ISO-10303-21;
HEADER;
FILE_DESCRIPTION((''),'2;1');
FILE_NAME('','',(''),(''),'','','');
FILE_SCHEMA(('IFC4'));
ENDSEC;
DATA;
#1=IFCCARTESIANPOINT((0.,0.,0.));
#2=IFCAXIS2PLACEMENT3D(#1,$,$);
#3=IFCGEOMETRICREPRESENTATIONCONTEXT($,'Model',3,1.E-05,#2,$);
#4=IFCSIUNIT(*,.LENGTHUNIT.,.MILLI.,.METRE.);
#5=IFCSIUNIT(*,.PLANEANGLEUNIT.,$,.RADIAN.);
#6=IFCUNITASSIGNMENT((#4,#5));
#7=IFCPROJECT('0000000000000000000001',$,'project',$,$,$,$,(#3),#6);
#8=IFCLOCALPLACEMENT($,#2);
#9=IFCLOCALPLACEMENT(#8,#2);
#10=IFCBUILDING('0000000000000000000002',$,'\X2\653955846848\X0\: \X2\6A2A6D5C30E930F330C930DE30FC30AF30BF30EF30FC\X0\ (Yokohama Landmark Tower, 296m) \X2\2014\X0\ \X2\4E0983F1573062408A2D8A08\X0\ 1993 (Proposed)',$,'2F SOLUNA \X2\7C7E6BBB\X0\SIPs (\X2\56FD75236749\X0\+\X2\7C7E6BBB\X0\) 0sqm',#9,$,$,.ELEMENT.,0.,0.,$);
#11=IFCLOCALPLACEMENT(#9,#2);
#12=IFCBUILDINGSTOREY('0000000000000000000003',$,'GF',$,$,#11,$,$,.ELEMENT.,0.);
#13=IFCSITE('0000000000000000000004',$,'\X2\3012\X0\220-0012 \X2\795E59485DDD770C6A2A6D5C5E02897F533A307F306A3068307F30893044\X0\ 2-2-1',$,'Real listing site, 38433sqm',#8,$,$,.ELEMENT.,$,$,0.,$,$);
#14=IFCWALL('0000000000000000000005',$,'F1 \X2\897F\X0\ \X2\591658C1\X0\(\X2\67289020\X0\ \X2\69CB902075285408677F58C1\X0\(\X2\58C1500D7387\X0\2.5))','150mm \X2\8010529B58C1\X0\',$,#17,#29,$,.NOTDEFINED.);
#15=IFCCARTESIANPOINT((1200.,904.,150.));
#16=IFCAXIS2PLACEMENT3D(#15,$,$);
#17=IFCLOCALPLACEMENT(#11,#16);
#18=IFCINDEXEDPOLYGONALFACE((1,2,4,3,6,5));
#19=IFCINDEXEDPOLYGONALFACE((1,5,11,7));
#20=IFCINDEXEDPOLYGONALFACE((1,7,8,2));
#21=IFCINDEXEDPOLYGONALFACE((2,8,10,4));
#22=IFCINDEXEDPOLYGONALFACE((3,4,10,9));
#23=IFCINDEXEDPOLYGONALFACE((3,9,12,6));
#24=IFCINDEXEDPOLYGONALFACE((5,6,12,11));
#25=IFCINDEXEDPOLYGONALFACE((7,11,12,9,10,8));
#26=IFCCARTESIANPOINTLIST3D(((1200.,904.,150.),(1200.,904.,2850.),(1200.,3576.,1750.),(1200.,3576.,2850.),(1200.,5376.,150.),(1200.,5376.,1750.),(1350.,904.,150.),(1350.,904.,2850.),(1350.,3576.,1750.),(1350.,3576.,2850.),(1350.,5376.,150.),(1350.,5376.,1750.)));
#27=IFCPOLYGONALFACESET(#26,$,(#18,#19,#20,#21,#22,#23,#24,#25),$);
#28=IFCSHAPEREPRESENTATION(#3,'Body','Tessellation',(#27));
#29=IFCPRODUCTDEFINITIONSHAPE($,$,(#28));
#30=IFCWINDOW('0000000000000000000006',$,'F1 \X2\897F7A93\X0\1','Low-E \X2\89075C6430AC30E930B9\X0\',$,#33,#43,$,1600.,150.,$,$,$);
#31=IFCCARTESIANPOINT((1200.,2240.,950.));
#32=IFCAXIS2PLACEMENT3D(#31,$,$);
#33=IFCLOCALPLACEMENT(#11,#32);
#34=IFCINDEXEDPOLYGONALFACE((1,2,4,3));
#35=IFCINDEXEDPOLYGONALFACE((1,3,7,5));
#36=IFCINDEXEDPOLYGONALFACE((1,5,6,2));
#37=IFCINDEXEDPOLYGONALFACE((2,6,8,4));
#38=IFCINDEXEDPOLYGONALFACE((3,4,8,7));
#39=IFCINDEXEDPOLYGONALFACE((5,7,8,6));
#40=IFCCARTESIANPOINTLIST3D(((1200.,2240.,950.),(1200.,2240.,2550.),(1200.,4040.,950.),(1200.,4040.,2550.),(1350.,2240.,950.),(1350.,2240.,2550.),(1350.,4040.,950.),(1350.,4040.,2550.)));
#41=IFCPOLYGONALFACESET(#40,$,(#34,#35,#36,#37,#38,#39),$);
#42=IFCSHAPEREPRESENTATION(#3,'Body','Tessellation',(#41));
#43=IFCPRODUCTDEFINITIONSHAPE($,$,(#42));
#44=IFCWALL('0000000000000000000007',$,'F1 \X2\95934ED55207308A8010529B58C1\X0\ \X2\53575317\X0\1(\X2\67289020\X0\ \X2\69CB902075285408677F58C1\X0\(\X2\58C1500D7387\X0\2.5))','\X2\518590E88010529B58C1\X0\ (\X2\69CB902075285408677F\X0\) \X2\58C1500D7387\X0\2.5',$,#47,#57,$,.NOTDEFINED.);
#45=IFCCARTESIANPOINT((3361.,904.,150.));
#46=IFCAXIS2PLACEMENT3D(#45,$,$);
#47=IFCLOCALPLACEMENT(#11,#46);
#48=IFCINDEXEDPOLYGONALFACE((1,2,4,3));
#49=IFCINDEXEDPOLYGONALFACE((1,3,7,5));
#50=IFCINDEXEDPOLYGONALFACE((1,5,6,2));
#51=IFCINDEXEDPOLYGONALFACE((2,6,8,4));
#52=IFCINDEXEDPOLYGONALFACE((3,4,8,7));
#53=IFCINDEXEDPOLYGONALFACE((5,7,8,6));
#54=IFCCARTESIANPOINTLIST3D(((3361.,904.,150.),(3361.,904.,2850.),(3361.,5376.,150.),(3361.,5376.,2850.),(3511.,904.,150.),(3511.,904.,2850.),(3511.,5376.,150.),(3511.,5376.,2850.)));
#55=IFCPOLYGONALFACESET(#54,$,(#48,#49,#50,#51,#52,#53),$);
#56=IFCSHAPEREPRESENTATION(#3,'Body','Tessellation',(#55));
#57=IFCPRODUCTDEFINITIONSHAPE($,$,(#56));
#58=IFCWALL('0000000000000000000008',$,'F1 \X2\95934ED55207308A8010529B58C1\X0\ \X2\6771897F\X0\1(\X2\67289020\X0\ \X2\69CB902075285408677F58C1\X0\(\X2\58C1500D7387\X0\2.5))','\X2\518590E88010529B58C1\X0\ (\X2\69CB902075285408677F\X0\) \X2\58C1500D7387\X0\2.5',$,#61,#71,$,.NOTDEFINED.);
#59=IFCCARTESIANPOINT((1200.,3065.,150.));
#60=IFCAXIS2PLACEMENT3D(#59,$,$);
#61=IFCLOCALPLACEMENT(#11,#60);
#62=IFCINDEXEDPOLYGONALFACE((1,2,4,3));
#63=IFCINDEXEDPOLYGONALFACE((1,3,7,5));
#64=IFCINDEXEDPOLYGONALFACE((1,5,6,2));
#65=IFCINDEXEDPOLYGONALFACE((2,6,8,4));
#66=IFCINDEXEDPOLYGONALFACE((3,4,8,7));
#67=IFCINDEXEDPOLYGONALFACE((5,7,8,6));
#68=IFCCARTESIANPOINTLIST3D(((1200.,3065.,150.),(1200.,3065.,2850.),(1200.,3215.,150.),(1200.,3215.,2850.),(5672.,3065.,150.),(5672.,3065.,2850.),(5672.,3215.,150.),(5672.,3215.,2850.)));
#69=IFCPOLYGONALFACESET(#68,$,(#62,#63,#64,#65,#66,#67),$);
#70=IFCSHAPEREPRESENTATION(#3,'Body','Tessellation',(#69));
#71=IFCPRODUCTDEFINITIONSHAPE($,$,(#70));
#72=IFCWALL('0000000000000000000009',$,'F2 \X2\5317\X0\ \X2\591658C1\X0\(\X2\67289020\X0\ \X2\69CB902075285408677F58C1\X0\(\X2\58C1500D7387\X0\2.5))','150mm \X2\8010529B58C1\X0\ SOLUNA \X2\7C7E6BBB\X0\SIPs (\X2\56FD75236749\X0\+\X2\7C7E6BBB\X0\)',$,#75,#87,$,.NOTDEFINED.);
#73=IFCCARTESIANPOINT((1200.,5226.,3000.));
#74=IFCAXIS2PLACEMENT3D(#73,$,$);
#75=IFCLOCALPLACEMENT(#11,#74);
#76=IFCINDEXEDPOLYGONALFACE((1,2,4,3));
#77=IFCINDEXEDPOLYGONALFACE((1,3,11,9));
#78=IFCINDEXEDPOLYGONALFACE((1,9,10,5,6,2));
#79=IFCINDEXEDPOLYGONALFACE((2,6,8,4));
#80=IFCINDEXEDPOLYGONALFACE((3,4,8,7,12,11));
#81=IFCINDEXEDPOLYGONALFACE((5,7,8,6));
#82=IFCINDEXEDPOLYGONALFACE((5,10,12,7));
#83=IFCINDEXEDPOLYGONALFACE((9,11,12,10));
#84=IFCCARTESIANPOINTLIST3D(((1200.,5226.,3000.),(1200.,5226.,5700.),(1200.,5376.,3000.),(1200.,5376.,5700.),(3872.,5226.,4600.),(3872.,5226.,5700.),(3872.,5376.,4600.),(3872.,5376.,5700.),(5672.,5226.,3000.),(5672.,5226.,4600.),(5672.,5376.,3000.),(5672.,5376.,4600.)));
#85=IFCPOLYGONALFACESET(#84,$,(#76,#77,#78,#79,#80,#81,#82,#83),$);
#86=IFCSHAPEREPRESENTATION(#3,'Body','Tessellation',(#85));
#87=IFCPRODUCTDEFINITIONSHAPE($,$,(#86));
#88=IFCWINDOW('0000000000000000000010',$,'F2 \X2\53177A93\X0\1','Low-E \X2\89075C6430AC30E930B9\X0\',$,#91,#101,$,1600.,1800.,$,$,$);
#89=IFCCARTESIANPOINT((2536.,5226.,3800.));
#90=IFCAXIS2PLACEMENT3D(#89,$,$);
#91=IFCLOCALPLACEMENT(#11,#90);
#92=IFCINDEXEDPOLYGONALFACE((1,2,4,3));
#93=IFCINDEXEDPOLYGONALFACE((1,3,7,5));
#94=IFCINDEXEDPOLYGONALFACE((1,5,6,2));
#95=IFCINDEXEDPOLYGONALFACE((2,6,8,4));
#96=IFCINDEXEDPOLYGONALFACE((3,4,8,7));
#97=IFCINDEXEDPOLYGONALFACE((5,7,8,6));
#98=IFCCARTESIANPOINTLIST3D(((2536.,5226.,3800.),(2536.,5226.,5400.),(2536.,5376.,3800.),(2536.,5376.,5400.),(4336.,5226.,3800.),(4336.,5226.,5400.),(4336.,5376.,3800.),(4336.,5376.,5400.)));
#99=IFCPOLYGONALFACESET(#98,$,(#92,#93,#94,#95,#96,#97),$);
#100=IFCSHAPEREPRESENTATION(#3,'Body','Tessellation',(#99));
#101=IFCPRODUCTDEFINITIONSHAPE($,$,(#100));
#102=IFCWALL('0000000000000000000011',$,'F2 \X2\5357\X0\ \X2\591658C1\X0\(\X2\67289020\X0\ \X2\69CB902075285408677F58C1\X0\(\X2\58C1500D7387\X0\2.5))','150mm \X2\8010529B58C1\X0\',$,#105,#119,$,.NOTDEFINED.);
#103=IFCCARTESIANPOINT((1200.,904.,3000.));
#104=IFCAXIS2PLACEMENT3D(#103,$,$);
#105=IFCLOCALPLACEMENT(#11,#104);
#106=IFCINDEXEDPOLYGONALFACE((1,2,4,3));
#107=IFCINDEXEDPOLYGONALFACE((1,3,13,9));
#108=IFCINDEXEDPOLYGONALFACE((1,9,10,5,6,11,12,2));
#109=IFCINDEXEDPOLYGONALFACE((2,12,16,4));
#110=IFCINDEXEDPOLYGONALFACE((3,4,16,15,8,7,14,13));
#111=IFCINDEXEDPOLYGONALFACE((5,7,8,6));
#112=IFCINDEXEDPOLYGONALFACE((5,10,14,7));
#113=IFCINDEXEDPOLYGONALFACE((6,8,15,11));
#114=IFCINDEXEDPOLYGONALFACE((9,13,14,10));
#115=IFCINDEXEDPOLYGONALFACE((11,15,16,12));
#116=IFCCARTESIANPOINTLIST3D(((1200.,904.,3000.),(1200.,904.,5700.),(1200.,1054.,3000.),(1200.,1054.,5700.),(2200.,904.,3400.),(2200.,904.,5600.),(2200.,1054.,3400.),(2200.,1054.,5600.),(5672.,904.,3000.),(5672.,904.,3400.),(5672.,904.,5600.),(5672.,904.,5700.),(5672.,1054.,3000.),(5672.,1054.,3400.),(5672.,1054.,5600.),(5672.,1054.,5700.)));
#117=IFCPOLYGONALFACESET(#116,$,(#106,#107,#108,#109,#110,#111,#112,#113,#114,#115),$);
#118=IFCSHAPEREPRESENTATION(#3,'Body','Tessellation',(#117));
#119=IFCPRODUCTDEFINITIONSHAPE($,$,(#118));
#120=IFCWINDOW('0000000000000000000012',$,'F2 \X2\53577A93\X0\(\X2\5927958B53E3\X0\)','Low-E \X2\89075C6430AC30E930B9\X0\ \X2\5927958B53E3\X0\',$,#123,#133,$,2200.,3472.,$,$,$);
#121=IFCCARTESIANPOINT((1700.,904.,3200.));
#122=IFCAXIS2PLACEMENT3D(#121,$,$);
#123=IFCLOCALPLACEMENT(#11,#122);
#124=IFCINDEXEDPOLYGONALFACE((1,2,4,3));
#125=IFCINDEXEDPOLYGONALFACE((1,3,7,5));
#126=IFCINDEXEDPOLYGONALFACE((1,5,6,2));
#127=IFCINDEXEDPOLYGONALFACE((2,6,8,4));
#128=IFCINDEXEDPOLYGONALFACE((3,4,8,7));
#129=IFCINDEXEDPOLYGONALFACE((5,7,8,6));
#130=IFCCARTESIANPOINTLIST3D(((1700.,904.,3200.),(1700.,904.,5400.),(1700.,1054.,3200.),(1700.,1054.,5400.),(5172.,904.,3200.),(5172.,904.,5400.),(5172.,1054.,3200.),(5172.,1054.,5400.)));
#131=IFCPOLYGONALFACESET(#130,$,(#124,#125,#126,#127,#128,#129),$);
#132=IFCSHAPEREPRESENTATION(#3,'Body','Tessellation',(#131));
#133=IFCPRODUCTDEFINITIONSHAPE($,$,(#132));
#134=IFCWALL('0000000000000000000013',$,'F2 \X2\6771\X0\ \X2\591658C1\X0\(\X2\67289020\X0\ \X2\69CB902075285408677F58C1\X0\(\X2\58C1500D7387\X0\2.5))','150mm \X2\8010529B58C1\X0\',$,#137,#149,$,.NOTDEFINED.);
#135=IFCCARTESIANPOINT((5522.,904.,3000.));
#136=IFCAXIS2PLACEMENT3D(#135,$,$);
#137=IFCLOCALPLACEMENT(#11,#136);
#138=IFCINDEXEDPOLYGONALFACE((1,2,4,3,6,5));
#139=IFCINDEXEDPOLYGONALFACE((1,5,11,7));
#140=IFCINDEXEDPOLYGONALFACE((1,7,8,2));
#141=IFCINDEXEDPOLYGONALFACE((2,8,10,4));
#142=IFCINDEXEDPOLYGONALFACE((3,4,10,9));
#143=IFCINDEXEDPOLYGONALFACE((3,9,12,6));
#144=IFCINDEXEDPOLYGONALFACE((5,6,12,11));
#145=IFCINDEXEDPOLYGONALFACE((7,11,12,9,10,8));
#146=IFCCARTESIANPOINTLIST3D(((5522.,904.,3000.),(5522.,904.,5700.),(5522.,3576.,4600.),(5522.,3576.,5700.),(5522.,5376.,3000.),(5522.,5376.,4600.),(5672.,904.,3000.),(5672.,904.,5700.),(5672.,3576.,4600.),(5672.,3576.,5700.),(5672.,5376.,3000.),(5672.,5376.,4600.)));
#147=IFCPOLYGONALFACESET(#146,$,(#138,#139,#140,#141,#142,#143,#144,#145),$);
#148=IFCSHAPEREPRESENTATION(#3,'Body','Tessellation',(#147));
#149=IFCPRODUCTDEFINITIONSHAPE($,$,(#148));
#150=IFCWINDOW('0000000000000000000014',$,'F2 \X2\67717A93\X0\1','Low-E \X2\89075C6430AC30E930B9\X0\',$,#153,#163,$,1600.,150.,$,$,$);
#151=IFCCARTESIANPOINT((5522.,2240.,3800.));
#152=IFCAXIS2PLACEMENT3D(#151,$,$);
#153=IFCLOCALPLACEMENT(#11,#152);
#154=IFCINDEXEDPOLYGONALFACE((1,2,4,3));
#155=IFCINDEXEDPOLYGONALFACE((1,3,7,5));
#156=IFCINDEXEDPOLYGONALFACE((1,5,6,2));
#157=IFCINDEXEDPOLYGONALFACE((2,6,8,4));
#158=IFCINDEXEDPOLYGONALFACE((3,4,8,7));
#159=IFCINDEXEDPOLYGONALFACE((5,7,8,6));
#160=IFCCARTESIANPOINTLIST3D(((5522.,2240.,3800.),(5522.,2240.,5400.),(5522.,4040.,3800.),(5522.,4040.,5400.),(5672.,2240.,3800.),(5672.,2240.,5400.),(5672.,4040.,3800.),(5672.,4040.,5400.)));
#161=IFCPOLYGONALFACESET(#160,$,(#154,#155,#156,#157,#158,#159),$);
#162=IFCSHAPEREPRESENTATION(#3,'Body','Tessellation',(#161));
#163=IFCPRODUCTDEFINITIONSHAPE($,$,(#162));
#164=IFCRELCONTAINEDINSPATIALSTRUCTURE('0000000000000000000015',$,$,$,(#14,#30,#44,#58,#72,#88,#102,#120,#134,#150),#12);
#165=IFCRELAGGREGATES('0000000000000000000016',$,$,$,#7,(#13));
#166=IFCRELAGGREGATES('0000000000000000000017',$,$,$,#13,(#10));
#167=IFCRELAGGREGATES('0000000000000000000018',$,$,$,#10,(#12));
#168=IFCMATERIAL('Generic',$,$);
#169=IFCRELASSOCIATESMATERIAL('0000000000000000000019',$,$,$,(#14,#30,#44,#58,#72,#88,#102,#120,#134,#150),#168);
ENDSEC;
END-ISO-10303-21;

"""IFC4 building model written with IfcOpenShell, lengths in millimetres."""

from ifc_helpers import new_model, si_unit, frame, frame_2d, origin, place, context, project, spatial, rectangle, extrude, material, element, fill, save


model = new_model("IFC4")

# Units and contexts
model_context = context("Model", 3, precision=1e-05, world=origin())
ifc_project = project(units=[si_unit("LENGTHUNIT", "METRE", prefix="MILLI"), si_unit("PLANEANGLEUNIT", "RADIAN")], contexts=[model_context])

# Site, building, storey
site_placement = place(None, origin())
site = spatial("IfcSite", under=ifc_project, at=site_placement, Name="〒220-0012 神奈川県横浜市西区みなとみらい 2-2-1", ObjectType="Real listing site, 38433sqm", CompositionType="ELEMENT", RefElevation=0.0)
building_placement = place(site_placement, origin())
building = spatial("IfcBuilding", under=site, at=building_placement, Name="改善案: 横浜ランドマークタワー (Yokohama Landmark Tower, 296m) — 三菱地所設計 1993 (Proposed)", ObjectType="2F SOLUNA 籾殻SIPs (国産杉+籾殻) 0sqm", CompositionType="ELEMENT", ElevationOfRefHeight=0.0, ElevationOfTerrain=0.0)
storey_placement = place(building_placement, origin())
storey = spatial("IfcBuildingStorey", under=building, at=storey_placement, Name="GF", CompositionType="ELEMENT", Elevation=0.0)

# Shared definitions
ifc_material_1 = material(Name="Generic")

# Wall, opening, window
wall_1_placement = place(storey_placement, frame((1200.0, 904.0, 150.0)))
wall_1 = element("IfcWall", 1, at=wall_1_placement, inside=storey, material=ifc_material_1, Name="F1 西 外壁(木造 構造用合板壁(壁倍率2.5))", Description="150mm 耐力壁", PredefinedType="NOTDEFINED", context=model_context, shape_type="SweptSolid", body=[
    extrude(rectangle(XDim=150.0, YDim=4472.0, at=frame_2d((75.0, 2236.0))), frame((1200.0, 904.0, 150.0)), (0.0, 0.0, 1.0), 2700.0),
])
opening_1_placement = place(storey_placement, frame((1200.0, 2240.0, 950.0)))
opening_1 = element("IfcOpeningElement", 2, at=opening_1_placement, cuts=wall_1, PredefinedType="NOTDEFINED", context=model_context, shape_type="SweptSolid", body=[
    extrude(rectangle(XDim=150.0, YDim=1800.0, at=frame_2d((75.0, 900.0))), frame((1200.0, 2240.0, 950.0)), (0.0, 0.0, 1.0), 1600.0),
])
window_1_placement = place(storey_placement, frame((1200.0, 2240.0, 950.0)))
window_1 = element("IfcWindow", 3, at=window_1_placement, inside=storey, material=ifc_material_1, Name="F1 西窓1", Description="Low-E 複層ガラス", OverallHeight=1600.0, OverallWidth=150.0, context=model_context, shape_type="SweptSolid", body=[
    extrude(rectangle(XDim=150.0, YDim=1800.0, at=frame_2d((75.0, 900.0))), frame((1200.0, 2240.0, 950.0)), (0.0, 0.0, 1.0), 1600.0),
])
fill(opening_1, window_1)

# Walls
wall_2_placement = place(storey_placement, frame((3361.0, 904.0, 150.0)))
element("IfcWall", 4, at=wall_2_placement, inside=storey, material=ifc_material_1, Name="F1 間仕切り耐力壁 南北1(木造 構造用合板壁(壁倍率2.5))", Description="内部耐力壁 (構造用合板) 壁倍率2.5", PredefinedType="NOTDEFINED", context=model_context, shape_type="SweptSolid", body=[
    extrude(rectangle(XDim=150.0, YDim=4472.0, at=frame_2d((75.0, 2236.0))), frame((3361.0, 904.0, 150.0)), (0.0, 0.0, 1.0), 2700.0),
])
wall_3_placement = place(storey_placement, frame((1200.0, 3065.0, 150.0)))
element("IfcWall", 5, at=wall_3_placement, inside=storey, material=ifc_material_1, Name="F1 間仕切り耐力壁 東西1(木造 構造用合板壁(壁倍率2.5))", Description="内部耐力壁 (構造用合板) 壁倍率2.5", PredefinedType="NOTDEFINED", context=model_context, shape_type="SweptSolid", body=[
    extrude(rectangle(XDim=4472.0, YDim=150.0, at=frame_2d((2236.0, 75.0))), frame((1200.0, 3065.0, 150.0)), (0.0, 0.0, 1.0), 2700.0),
])

# Walls, openings, windows
wall_4_placement = place(storey_placement, frame((1200.0, 5226.0, 3000.0)))
wall_4 = element("IfcWall", 6, at=wall_4_placement, inside=storey, material=ifc_material_1, Name="F2 北 外壁(木造 構造用合板壁(壁倍率2.5))", Description="150mm 耐力壁 SOLUNA 籾殻SIPs (国産杉+籾殻)", PredefinedType="NOTDEFINED", context=model_context, shape_type="SweptSolid", body=[
    extrude(rectangle(XDim=4472.0, YDim=150.0, at=frame_2d((2236.0, 75.0))), frame((1200.0, 5226.0, 3000.0)), (0.0, 0.0, 1.0), 2700.0),
])
opening_2_placement = place(storey_placement, frame((2536.0, 5226.0, 3800.0)))
opening_2 = element("IfcOpeningElement", 7, at=opening_2_placement, cuts=wall_4, PredefinedType="NOTDEFINED", context=model_context, shape_type="SweptSolid", body=[
    extrude(rectangle(XDim=1800.0, YDim=150.0, at=frame_2d((900.0, 75.0))), frame((2536.0, 5226.0, 3800.0)), (0.0, 0.0, 1.0), 1600.0),
])
window_2_placement = place(storey_placement, frame((2536.0, 5226.0, 3800.0)))
window_2 = element("IfcWindow", 8, at=window_2_placement, inside=storey, material=ifc_material_1, Name="F2 北窓1", Description="Low-E 複層ガラス", OverallHeight=1600.0, OverallWidth=1800.0, context=model_context, shape_type="SweptSolid", body=[
    extrude(rectangle(XDim=1800.0, YDim=150.0, at=frame_2d((900.0, 75.0))), frame((2536.0, 5226.0, 3800.0)), (0.0, 0.0, 1.0), 1600.0),
])
fill(opening_2, window_2)
wall_5_placement = place(storey_placement, frame((1200.0, 904.0, 3000.0)))
wall_5 = element("IfcWall", 9, at=wall_5_placement, inside=storey, material=ifc_material_1, Name="F2 南 外壁(木造 構造用合板壁(壁倍率2.5))", Description="150mm 耐力壁", PredefinedType="NOTDEFINED", context=model_context, shape_type="SweptSolid", body=[
    extrude(rectangle(XDim=4472.0, YDim=150.0, at=frame_2d((2236.0, 75.0))), frame((1200.0, 904.0, 3000.0)), (0.0, 0.0, 1.0), 2700.0),
])
opening_3_placement = place(storey_placement, frame((1700.0, 904.0, 3200.0)))
opening_3 = element("IfcOpeningElement", 10, at=opening_3_placement, cuts=wall_5, PredefinedType="NOTDEFINED", context=model_context, shape_type="SweptSolid", body=[
    extrude(rectangle(XDim=3472.0, YDim=150.0, at=frame_2d((1736.0, 75.0))), frame((1700.0, 904.0, 3200.0)), (0.0, 0.0, 1.0), 2200.0),
])
window_3_placement = place(storey_placement, frame((1700.0, 904.0, 3200.0)))
window_3 = element("IfcWindow", 11, at=window_3_placement, inside=storey, material=ifc_material_1, Name="F2 南窓(大開口)", Description="Low-E 複層ガラス 大開口", OverallHeight=2200.0, OverallWidth=3472.0, context=model_context, shape_type="SweptSolid", body=[
    extrude(rectangle(XDim=3472.0, YDim=150.0, at=frame_2d((1736.0, 75.0))), frame((1700.0, 904.0, 3200.0)), (0.0, 0.0, 1.0), 2200.0),
])
fill(opening_3, window_3)
wall_6_placement = place(storey_placement, frame((5522.0, 904.0, 3000.0)))
wall_6 = element("IfcWall", 12, at=wall_6_placement, inside=storey, material=ifc_material_1, Name="F2 東 外壁(木造 構造用合板壁(壁倍率2.5))", Description="150mm 耐力壁", PredefinedType="NOTDEFINED", context=model_context, shape_type="SweptSolid", body=[
    extrude(rectangle(XDim=150.0, YDim=4472.0, at=frame_2d((75.0, 2236.0))), frame((5522.0, 904.0, 3000.0)), (0.0, 0.0, 1.0), 2700.0),
])
opening_4_placement = place(storey_placement, frame((5522.0, 2240.0, 3800.0)))
opening_4 = element("IfcOpeningElement", 13, at=opening_4_placement, cuts=wall_6, PredefinedType="NOTDEFINED", context=model_context, shape_type="SweptSolid", body=[
    extrude(rectangle(XDim=150.0, YDim=1800.0, at=frame_2d((75.0, 900.0))), frame((5522.0, 2240.0, 3800.0)), (0.0, 0.0, 1.0), 1600.0),
])
window_4_placement = place(storey_placement, frame((5522.0, 2240.0, 3800.0)))
window_4 = element("IfcWindow", 14, at=window_4_placement, inside=storey, material=ifc_material_1, Name="F2 東窓1", Description="Low-E 複層ガラス", OverallHeight=1600.0, OverallWidth=150.0, context=model_context, shape_type="SweptSolid", body=[
    extrude(rectangle(XDim=150.0, YDim=1800.0, at=frame_2d((75.0, 900.0))), frame((5522.0, 2240.0, 3800.0)), (0.0, 0.0, 1.0), 1600.0),
])
fill(opening_4, window_4)

save(model, "model.ifc")
